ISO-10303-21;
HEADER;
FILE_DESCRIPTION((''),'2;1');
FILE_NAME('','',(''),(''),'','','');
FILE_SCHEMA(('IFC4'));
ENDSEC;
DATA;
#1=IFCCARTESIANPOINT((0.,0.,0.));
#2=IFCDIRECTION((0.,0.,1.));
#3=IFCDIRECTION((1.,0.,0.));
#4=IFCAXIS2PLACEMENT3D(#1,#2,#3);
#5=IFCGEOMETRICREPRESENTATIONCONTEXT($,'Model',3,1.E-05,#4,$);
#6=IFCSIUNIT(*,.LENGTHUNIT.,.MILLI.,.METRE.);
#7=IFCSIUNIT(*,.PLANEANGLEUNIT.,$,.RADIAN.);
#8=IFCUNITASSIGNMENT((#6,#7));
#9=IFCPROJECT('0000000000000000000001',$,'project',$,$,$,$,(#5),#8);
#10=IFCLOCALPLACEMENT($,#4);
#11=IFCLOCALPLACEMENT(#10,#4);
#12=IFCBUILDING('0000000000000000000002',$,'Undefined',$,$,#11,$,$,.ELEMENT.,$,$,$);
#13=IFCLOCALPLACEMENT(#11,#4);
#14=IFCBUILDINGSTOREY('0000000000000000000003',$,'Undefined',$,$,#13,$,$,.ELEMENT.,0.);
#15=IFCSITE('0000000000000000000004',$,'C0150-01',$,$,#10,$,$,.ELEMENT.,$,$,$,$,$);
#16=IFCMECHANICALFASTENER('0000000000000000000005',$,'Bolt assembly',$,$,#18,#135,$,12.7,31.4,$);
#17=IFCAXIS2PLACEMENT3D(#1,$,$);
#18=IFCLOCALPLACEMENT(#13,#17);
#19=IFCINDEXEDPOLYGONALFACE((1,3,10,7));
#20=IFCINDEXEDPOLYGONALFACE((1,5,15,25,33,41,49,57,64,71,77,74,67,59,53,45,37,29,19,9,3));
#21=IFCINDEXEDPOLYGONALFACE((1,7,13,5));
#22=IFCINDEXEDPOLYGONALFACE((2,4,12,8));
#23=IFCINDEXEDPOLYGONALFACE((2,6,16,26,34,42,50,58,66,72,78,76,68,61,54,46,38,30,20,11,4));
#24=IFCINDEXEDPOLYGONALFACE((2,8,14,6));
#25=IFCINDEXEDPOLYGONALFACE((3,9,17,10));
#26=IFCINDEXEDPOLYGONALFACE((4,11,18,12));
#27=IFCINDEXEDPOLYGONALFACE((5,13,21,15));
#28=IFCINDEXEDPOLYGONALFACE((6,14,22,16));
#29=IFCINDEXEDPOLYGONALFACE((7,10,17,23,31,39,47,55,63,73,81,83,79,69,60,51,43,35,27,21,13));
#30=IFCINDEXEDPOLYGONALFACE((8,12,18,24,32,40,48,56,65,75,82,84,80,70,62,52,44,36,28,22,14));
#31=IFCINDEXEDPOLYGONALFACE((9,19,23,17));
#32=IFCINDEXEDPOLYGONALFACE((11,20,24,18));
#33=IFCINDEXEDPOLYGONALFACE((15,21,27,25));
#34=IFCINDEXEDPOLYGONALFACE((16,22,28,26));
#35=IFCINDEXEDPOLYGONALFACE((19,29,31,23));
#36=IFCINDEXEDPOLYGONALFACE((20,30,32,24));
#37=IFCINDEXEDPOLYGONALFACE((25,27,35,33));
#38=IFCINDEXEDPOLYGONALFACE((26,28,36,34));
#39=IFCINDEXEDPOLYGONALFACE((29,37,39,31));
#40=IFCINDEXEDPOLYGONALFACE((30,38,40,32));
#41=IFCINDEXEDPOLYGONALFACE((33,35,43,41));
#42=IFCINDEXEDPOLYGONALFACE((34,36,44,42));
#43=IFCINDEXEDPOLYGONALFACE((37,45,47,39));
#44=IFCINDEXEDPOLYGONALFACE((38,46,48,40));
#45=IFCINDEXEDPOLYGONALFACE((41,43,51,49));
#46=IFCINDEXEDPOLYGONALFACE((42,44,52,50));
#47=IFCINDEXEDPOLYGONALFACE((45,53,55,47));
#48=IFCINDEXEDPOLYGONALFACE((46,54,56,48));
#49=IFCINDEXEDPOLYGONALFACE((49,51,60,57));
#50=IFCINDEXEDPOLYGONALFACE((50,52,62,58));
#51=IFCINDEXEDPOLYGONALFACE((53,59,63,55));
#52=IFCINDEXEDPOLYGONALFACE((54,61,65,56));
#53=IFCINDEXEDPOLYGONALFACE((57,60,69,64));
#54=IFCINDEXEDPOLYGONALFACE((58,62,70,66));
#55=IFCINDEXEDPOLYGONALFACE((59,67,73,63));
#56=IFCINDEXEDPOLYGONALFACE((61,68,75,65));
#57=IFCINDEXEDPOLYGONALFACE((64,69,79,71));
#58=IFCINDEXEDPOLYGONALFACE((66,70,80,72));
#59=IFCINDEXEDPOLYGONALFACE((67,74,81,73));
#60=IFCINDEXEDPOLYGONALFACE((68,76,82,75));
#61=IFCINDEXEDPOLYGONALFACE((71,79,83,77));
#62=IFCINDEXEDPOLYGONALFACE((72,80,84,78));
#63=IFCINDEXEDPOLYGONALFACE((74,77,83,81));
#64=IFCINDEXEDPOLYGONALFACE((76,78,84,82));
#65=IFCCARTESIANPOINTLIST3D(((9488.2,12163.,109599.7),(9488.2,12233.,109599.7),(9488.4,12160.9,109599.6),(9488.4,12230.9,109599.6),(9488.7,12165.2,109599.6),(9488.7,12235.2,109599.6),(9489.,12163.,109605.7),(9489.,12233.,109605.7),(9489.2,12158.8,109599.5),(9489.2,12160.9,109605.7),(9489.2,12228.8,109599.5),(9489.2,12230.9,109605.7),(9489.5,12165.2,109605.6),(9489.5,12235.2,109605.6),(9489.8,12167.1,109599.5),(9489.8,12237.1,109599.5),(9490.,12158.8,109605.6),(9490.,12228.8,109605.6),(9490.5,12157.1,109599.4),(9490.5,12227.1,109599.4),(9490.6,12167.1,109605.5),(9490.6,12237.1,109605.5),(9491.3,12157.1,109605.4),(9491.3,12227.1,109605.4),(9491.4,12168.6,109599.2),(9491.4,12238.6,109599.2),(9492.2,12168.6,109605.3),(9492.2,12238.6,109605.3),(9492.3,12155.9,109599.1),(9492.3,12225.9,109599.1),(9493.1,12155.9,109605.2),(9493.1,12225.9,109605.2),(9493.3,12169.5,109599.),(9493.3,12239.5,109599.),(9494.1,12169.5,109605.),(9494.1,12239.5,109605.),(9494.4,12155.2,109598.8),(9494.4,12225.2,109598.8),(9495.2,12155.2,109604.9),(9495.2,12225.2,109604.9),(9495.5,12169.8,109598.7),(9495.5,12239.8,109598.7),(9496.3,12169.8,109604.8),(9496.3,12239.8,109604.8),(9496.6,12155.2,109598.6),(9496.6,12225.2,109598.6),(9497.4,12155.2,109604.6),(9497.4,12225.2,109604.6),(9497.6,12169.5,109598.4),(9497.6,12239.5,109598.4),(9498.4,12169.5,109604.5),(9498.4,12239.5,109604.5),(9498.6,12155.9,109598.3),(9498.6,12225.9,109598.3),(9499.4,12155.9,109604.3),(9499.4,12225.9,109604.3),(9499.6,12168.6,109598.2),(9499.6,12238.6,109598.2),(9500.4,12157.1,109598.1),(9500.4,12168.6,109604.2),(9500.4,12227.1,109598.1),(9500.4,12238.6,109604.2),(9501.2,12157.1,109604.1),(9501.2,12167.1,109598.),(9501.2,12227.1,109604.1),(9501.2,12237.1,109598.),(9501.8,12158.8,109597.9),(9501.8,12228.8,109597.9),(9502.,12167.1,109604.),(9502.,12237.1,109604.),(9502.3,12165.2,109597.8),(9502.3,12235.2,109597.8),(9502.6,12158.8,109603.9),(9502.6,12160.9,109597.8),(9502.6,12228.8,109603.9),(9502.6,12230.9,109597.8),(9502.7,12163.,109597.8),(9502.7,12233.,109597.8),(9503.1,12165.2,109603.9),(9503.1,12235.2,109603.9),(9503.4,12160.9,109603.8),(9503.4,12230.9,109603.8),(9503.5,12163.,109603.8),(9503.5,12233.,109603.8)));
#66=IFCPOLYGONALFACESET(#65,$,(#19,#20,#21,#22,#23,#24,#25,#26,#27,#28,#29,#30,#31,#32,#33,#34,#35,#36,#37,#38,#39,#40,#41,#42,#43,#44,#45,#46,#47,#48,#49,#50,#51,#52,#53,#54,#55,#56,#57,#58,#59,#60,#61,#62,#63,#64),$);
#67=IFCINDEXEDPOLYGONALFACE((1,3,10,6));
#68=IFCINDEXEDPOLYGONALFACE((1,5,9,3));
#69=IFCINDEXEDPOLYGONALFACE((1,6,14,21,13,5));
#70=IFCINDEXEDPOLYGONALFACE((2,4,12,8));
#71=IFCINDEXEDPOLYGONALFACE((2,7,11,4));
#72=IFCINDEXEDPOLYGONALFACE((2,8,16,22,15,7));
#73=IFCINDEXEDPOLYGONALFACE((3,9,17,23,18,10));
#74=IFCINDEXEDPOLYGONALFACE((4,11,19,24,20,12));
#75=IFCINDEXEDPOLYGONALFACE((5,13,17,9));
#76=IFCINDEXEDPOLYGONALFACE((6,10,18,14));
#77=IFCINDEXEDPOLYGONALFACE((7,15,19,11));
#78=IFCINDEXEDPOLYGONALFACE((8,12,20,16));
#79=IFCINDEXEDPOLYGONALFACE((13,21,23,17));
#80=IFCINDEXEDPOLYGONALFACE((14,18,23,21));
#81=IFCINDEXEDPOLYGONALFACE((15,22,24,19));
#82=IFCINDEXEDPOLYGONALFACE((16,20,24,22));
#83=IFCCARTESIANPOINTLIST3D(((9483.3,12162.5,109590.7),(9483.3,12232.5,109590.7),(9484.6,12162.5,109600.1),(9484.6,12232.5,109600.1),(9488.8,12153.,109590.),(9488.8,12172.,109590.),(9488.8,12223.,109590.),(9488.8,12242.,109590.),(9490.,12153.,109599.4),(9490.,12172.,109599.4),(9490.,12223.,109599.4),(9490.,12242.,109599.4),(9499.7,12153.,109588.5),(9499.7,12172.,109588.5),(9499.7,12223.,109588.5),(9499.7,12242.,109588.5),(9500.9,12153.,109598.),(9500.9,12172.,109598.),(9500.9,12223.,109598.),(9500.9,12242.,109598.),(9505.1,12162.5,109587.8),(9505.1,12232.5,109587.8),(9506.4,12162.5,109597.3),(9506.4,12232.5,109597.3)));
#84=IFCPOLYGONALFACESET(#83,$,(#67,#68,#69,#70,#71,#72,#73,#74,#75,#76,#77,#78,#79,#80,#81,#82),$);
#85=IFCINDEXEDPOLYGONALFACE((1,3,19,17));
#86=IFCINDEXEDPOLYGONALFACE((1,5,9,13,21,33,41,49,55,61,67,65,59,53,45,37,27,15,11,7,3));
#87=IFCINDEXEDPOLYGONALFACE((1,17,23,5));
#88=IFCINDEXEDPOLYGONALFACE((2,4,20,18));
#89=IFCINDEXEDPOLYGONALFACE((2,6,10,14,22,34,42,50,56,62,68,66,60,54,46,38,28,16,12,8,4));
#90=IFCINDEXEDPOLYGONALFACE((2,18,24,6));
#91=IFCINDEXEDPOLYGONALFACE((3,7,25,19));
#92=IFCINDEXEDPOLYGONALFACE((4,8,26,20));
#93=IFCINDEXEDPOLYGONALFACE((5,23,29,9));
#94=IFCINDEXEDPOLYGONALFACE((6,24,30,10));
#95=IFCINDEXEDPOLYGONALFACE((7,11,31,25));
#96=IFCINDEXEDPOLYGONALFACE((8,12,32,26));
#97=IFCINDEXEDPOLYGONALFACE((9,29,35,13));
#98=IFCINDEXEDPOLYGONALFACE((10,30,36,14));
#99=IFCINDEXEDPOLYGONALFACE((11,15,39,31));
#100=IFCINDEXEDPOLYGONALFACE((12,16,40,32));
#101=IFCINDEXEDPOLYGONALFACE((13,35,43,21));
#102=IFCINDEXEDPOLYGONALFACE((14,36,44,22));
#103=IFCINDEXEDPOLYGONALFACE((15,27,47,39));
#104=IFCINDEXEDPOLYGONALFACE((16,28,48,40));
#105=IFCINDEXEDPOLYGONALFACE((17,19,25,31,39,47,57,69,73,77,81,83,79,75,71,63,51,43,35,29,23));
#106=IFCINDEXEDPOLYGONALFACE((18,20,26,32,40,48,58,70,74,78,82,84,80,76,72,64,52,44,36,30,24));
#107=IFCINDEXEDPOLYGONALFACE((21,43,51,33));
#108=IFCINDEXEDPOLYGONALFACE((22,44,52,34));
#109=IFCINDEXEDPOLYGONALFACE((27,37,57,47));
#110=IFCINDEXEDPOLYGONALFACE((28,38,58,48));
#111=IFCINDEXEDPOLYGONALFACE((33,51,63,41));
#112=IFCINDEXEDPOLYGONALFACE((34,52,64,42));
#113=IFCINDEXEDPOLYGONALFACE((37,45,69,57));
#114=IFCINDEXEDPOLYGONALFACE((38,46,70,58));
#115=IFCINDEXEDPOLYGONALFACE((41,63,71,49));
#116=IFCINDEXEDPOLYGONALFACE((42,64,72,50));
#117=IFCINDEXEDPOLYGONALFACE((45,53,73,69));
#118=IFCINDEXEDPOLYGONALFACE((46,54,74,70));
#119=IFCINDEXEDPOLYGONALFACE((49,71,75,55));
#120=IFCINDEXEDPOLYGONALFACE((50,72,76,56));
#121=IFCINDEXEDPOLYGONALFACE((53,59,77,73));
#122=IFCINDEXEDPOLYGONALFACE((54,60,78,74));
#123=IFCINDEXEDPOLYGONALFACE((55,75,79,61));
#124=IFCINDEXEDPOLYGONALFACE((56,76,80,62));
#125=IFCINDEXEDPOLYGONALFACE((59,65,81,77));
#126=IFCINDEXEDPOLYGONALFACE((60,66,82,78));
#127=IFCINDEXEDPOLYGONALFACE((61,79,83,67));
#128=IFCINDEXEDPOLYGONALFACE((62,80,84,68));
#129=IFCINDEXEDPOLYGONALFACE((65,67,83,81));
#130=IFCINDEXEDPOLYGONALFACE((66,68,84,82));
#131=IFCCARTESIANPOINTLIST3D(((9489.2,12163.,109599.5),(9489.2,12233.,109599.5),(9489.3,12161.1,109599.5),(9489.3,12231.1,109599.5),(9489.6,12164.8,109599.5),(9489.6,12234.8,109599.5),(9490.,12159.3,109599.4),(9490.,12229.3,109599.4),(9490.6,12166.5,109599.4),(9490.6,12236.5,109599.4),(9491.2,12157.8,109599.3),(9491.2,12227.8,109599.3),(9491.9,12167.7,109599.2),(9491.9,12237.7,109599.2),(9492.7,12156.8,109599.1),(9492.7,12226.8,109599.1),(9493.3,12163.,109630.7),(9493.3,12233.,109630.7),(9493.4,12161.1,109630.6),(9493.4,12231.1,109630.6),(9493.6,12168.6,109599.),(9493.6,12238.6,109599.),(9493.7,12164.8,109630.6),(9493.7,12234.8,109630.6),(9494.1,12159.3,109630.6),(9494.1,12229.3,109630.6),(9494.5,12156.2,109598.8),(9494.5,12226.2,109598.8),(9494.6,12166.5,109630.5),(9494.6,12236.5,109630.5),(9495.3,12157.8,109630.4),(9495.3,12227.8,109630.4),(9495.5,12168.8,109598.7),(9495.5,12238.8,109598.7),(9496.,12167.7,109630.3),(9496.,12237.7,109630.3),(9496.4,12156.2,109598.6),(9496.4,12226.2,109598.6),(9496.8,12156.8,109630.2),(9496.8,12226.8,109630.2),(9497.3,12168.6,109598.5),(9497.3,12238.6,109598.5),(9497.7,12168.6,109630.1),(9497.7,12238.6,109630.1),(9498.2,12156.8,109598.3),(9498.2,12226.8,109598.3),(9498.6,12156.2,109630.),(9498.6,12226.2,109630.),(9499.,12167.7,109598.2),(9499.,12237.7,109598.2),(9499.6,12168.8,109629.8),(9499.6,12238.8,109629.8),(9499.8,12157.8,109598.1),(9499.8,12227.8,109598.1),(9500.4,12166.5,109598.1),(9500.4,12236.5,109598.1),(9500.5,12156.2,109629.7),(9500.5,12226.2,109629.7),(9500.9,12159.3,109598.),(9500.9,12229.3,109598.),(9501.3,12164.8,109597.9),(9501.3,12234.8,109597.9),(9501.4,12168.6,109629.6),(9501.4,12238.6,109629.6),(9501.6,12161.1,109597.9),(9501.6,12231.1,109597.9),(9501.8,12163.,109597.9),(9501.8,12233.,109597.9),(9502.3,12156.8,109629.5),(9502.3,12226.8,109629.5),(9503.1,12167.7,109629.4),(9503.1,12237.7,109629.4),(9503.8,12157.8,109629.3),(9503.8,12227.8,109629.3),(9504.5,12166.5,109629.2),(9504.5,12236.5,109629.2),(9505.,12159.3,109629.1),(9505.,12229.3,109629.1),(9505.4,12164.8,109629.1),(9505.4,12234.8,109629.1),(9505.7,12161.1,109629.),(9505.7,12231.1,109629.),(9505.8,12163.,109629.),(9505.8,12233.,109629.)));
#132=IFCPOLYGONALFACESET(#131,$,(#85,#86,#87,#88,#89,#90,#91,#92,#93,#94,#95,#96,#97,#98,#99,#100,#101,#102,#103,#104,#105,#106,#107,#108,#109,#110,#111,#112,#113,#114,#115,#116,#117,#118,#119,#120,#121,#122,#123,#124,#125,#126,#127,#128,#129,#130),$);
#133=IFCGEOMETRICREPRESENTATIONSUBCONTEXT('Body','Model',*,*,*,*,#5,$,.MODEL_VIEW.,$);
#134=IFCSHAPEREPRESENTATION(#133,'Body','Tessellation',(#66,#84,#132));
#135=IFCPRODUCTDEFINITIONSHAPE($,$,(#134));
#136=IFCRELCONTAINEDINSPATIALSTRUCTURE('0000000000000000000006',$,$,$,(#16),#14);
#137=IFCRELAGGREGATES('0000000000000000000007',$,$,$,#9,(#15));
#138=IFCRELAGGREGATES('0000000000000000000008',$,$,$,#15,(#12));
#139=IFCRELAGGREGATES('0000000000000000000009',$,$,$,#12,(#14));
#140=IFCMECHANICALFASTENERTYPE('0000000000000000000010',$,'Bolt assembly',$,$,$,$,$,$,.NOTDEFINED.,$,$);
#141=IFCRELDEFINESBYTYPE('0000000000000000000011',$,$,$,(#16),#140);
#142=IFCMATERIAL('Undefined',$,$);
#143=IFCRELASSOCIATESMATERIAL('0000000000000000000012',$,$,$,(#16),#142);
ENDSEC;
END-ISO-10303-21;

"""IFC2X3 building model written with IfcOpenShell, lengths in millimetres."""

from ifc_helpers import new_model, si_unit, frame, origin_with_axes, origin_2d_with_axis, place, context, subcontext, project, spatial, polyline, circle, outline, extrude, source, transform, mapped, material, type_object, element, save


model = new_model("IFC2X3")

# Units and contexts
model_context = context("Model", 3, precision=1e-05, world=origin_with_axes())
body_context = subcontext(model_context, "Body", "Model", "MODEL_VIEW")
ifc_project = project(units=[si_unit("LENGTHUNIT", "METRE", prefix="MILLI"), si_unit("PLANEANGLEUNIT", "RADIAN")], contexts=[model_context])

# Site, building, storey
site_placement = place(None, origin_with_axes())
site = spatial("IfcSite", under=ifc_project, at=site_placement, Name="C0150-01", CompositionType="ELEMENT")
building_placement = place(site_placement, origin_with_axes())
building = spatial("IfcBuilding", under=site, at=building_placement, Name="Undefined", CompositionType="ELEMENT")
storey_placement = place(building_placement, origin_with_axes())
storey = spatial("IfcBuildingStorey", under=building, at=storey_placement, Name="Undefined", CompositionType="ELEMENT", Elevation=0.0)

# Mechanical fastener
ifc_material_1 = material(Name="Undefined")
mechanical_fastener_type = type_object("IfcMechanicalFastenerType", Name="Bolt assembly")
shared_shape_1 = source(origin_with_axes(), body_context, "Body", "SweptSolid", [
    extrude(circle(Radius=7.3, at=origin_2d_with_axis()), frame((0.0, -2.0, 0.0), z_axis=(0.0, 1.0, 0.0), x_axis=(1.0, 0.0, 0.0)), (0.0, 0.0, 1.0), 6.1),
    extrude(outline(polyline([(9.5, -5.5), (9.5, 5.5), (0.0, 11.0), (-9.5, 5.5), (-9.5, -5.5), (0.0, -11.0), (9.5, -5.5)])), frame((0.0, -11.5, 0.0), z_axis=(0.0, 1.0, 0.0), x_axis=(1.0, 0.0, 0.0)), (0.0, 0.0, 1.0), 9.5),
    extrude(circle(Radius=6.3, at=origin_2d_with_axis()), frame((0.0, -2.0, 0.0), z_axis=(0.0, 1.0, 0.0), x_axis=(1.0, 0.0, 0.0)), (0.0, 0.0, 1.0), 31.4),
])
for number, where, z_axis, x_axis, name in (
    (1, (9495.7, 12162.5, 109600.7), (0.991507, 0.0, -0.130054), (0.0, 1.0, 0.0), "Bolt assembly"),
):
    element("IfcMechanicalFastener", number, at=place(storey_placement, frame(where, z_axis=z_axis, x_axis=x_axis)), inside=storey, type_object=mechanical_fastener_type, material=ifc_material_1, Name=name, NominalDiameter=12.7, NominalLength=31.4, context=body_context, shape_type="MappedRepresentation", body=[
        mapped(shared_shape_1, transform((0.0, 0.0, 0.0))),
        mapped(shared_shape_1, transform((70.0, 0.0, 0.0))),
    ])

save(model, "model.ifc")
